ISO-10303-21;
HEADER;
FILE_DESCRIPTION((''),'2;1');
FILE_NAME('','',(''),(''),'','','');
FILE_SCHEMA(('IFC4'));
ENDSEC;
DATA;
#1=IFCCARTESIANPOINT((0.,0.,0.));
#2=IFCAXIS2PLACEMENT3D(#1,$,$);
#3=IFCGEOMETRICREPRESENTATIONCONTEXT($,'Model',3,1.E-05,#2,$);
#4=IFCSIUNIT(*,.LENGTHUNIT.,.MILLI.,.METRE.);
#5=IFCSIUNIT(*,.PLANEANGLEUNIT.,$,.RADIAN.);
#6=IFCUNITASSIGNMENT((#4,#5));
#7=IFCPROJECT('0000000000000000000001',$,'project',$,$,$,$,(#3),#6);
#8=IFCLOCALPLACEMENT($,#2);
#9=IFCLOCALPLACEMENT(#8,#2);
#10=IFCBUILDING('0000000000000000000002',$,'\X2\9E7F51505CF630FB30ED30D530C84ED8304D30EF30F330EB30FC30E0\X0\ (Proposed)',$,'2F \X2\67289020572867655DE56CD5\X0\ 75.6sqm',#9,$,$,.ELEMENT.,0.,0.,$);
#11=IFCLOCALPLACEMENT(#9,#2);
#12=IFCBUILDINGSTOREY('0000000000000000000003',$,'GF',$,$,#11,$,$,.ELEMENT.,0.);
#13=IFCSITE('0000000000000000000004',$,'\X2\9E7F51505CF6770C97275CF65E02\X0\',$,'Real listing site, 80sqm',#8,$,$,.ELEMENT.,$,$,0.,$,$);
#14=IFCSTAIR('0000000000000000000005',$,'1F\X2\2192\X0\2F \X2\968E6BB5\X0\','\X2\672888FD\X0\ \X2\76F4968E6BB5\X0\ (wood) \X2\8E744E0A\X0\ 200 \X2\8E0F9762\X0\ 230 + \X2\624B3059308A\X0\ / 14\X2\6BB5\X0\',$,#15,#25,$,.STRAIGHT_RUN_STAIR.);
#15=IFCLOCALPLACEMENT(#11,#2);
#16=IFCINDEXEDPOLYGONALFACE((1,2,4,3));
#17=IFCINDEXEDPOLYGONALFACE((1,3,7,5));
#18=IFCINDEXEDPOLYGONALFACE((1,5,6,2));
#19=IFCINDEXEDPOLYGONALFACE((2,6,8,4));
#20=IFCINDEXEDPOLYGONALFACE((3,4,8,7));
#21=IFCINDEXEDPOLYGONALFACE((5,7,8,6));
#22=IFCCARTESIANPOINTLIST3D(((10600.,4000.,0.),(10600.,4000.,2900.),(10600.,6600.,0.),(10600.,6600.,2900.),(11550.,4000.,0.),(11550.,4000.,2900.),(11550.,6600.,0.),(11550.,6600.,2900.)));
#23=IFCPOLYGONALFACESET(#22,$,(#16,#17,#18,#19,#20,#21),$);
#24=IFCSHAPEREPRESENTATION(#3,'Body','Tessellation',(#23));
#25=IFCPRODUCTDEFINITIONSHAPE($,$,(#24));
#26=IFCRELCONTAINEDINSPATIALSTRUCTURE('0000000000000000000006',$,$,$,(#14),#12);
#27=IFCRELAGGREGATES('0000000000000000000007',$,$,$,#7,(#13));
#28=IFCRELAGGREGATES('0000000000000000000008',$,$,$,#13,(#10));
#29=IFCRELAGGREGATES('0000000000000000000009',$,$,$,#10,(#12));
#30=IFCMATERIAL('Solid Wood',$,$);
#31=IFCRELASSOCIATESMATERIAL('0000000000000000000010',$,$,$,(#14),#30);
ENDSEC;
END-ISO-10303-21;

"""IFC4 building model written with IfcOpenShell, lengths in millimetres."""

from ifc_helpers import new_model, si_unit, frame, frame_2d, origin, place, context, project, spatial, rectangle, extrude, material, element, save


model = new_model("IFC4")

# Units and contexts
model_context = context("Model", 3, precision=1e-05, world=origin())
ifc_project = project(units=[si_unit("LENGTHUNIT", "METRE", prefix="MILLI"), si_unit("PLANEANGLEUNIT", "RADIAN")], contexts=[model_context])

# Site, building, storey
site_placement = place(None, origin())
site = spatial("IfcSite", under=ifc_project, at=site_placement, Name="鹿児島県霧島市", ObjectType="Real listing site, 80sqm", CompositionType="ELEMENT", RefElevation=0.0)
building_placement = place(site_placement, origin())
building = spatial("IfcBuilding", under=site, at=building_placement, Name="鹿児島・ロフト付きワンルーム (Proposed)", ObjectType="2F 木造在来工法 75.6sqm", CompositionType="ELEMENT", ElevationOfRefHeight=0.0, ElevationOfTerrain=0.0)
storey_placement = place(building_placement, origin())
storey = spatial("IfcBuildingStorey", under=building, at=storey_placement, Name="GF", CompositionType="ELEMENT", Elevation=0.0)

# Shared definitions
ifc_material_1 = material(Name="Solid Wood")

# Stair
stair_1_placement = place(storey_placement, frame((5300.0, 2000.0, 0.0)))
element("IfcStair", 1, at=stair_1_placement, inside=storey, material=ifc_material_1, Name="1F→2F 階段", Description="木製 直階段 (wood) 蹴上 200 踏面 230 + 手すり / 14段", PredefinedType="STRAIGHT_RUN_STAIR", context=model_context, shape_type="SweptSolid", body=[
    extrude(rectangle(XDim=950.0, YDim=2600.0, at=frame_2d((475.0, 1300.0))), frame((5300.0, 2000.0, 0.0)), (0.0, 0.0, 1.0), 2900.0),
])

save(model, "model.ifc")
